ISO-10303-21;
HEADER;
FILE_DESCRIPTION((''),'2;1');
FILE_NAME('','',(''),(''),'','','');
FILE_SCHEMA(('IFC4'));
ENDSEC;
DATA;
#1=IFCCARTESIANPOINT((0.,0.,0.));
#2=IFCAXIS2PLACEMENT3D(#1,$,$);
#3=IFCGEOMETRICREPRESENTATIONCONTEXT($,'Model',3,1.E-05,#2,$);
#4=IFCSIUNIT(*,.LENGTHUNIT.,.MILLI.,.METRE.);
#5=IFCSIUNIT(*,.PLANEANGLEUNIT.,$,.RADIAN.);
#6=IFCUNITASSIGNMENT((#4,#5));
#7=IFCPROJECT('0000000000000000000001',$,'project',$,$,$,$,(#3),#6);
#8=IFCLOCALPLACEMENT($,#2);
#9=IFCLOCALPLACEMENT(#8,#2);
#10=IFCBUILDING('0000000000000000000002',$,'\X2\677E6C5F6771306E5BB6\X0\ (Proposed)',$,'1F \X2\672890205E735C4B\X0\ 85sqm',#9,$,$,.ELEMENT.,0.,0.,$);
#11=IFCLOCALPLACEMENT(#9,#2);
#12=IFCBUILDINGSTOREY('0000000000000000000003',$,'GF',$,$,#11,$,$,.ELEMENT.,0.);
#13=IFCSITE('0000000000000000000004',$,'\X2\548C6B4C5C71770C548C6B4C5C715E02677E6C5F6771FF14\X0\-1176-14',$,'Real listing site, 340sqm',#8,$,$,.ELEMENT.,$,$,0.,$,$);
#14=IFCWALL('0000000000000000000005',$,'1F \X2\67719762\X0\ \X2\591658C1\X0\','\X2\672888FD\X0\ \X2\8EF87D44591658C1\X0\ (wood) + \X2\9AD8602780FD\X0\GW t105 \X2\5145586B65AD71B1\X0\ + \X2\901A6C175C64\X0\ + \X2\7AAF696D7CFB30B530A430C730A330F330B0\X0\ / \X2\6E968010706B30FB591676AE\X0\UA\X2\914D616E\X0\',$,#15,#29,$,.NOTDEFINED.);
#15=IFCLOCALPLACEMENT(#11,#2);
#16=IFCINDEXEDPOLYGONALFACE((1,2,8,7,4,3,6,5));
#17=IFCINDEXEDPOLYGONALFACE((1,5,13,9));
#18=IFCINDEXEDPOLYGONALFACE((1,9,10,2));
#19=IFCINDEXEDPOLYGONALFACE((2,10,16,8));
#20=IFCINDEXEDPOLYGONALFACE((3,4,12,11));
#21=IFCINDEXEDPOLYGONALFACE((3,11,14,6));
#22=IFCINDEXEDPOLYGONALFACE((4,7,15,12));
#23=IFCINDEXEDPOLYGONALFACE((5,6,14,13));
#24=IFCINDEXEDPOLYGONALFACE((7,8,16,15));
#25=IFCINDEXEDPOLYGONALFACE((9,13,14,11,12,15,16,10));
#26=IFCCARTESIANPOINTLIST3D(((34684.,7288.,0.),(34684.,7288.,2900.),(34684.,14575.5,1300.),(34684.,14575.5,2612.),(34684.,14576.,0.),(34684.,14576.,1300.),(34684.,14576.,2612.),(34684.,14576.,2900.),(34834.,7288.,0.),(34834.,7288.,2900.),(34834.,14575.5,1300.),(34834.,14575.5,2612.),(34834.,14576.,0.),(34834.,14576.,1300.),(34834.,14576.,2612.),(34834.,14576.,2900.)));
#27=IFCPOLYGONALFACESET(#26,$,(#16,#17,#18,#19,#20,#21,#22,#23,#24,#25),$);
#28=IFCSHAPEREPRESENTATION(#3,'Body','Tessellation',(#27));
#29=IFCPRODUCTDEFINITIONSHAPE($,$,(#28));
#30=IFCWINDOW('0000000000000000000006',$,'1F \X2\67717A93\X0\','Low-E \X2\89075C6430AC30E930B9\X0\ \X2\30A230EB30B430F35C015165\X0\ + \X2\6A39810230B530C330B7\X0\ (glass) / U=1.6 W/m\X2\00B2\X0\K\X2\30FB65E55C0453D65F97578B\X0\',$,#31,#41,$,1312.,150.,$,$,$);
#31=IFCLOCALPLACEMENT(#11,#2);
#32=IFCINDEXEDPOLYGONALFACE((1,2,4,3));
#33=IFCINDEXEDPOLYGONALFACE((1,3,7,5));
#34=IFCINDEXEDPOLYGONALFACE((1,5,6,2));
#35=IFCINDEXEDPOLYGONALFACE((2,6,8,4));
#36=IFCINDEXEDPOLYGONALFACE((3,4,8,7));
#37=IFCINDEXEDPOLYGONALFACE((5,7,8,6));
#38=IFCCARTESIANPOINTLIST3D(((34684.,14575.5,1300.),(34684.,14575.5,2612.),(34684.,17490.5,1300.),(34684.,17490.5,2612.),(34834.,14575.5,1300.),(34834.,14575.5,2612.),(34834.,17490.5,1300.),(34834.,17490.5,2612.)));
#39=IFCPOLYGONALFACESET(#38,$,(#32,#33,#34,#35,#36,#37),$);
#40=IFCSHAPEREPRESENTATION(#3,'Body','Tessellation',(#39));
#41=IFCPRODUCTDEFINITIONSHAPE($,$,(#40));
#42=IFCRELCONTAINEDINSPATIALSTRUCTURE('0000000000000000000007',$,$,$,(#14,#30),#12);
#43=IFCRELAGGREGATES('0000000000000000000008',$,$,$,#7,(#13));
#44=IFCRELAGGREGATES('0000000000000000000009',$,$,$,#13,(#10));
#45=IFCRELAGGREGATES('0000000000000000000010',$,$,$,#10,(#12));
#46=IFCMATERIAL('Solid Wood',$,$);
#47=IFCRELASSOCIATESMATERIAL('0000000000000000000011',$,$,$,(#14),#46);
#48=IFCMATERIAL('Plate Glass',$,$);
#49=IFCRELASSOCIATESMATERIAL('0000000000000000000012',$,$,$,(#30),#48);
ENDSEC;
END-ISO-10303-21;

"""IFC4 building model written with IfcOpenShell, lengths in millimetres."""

from ifc_helpers import new_model, si_unit, frame, frame_2d, origin, place, context, project, spatial, rectangle, extrude, material, element, fill, save


model = new_model("IFC4")

# Units and contexts
model_context = context("Model", 3, precision=1e-05, world=origin())
ifc_project = project(units=[si_unit("LENGTHUNIT", "METRE", prefix="MILLI"), si_unit("PLANEANGLEUNIT", "RADIAN")], contexts=[model_context])

# Site, building, storey
site_placement = place(None, origin())
site = spatial("IfcSite", under=ifc_project, at=site_placement, Name="和歌山県和歌山市松江東４-1176-14", ObjectType="Real listing site, 340sqm", CompositionType="ELEMENT", RefElevation=0.0)
building_placement = place(site_placement, origin())
building = spatial("IfcBuilding", under=site, at=building_placement, Name="松江東の家 (Proposed)", ObjectType="1F 木造平屋 85sqm", CompositionType="ELEMENT", ElevationOfRefHeight=0.0, ElevationOfTerrain=0.0)
storey_placement = place(building_placement, origin())
storey = spatial("IfcBuildingStorey", under=building, at=storey_placement, Name="GF", CompositionType="ELEMENT", Elevation=0.0)

# Wall, opening, window
ifc_material_1 = material(Name="Solid Wood")
wall_1_placement = place(storey_placement, frame((17342.0, 3644.0, 0.0)))
wall_1 = element("IfcWall", 1, at=wall_1_placement, inside=storey, material=ifc_material_1, Name="1F 東面 外壁", Description="木製 軸組外壁 (wood) + 高性能GW t105 充填断熱 + 通気層 + 窯業系サイディング / 準耐火・外皮UA配慮", PredefinedType="NOTDEFINED", context=model_context, shape_type="SweptSolid", body=[
    extrude(rectangle(XDim=150.0, YDim=7288.0, at=frame_2d((75.0, 3644.0))), frame((17342.0, 3644.0, 0.0)), (0.0, 0.0, 1.0), 2900.0),
])
opening_placement = place(storey_placement, frame((17342.0, 7288.0, 650.0)))
opening = element("IfcOpeningElement", 2, at=opening_placement, cuts=wall_1, PredefinedType="NOTDEFINED", context=model_context, shape_type="SweptSolid", body=[
    extrude(rectangle(XDim=150.0, YDim=2915.0, at=frame_2d((75.0, 1457.0))), frame((17342.0, 7288.0, 650.0)), (0.0, 0.0, 1.0), 1312.0),
])
ifc_material_2 = material(Name="Plate Glass")
window_1_placement = place(storey_placement, frame((17342.0, 7288.0, 650.0)))
window_1 = element("IfcWindow", 3, at=window_1_placement, inside=storey, material=ifc_material_2, Name="1F 東窓", Description="Low-E 複層ガラス アルゴン封入 + 樹脂サッシ (glass) / U=1.6 W/m²K・日射取得型", OverallHeight=1312.0, OverallWidth=150.0, context=model_context, shape_type="SweptSolid", body=[
    extrude(rectangle(XDim=150.0, YDim=2915.0, at=frame_2d((75.0, 1457.0))), frame((17342.0, 7288.0, 650.0)), (0.0, 0.0, 1.0), 1312.0),
])
fill(opening, window_1)

save(model, "model.ifc")
